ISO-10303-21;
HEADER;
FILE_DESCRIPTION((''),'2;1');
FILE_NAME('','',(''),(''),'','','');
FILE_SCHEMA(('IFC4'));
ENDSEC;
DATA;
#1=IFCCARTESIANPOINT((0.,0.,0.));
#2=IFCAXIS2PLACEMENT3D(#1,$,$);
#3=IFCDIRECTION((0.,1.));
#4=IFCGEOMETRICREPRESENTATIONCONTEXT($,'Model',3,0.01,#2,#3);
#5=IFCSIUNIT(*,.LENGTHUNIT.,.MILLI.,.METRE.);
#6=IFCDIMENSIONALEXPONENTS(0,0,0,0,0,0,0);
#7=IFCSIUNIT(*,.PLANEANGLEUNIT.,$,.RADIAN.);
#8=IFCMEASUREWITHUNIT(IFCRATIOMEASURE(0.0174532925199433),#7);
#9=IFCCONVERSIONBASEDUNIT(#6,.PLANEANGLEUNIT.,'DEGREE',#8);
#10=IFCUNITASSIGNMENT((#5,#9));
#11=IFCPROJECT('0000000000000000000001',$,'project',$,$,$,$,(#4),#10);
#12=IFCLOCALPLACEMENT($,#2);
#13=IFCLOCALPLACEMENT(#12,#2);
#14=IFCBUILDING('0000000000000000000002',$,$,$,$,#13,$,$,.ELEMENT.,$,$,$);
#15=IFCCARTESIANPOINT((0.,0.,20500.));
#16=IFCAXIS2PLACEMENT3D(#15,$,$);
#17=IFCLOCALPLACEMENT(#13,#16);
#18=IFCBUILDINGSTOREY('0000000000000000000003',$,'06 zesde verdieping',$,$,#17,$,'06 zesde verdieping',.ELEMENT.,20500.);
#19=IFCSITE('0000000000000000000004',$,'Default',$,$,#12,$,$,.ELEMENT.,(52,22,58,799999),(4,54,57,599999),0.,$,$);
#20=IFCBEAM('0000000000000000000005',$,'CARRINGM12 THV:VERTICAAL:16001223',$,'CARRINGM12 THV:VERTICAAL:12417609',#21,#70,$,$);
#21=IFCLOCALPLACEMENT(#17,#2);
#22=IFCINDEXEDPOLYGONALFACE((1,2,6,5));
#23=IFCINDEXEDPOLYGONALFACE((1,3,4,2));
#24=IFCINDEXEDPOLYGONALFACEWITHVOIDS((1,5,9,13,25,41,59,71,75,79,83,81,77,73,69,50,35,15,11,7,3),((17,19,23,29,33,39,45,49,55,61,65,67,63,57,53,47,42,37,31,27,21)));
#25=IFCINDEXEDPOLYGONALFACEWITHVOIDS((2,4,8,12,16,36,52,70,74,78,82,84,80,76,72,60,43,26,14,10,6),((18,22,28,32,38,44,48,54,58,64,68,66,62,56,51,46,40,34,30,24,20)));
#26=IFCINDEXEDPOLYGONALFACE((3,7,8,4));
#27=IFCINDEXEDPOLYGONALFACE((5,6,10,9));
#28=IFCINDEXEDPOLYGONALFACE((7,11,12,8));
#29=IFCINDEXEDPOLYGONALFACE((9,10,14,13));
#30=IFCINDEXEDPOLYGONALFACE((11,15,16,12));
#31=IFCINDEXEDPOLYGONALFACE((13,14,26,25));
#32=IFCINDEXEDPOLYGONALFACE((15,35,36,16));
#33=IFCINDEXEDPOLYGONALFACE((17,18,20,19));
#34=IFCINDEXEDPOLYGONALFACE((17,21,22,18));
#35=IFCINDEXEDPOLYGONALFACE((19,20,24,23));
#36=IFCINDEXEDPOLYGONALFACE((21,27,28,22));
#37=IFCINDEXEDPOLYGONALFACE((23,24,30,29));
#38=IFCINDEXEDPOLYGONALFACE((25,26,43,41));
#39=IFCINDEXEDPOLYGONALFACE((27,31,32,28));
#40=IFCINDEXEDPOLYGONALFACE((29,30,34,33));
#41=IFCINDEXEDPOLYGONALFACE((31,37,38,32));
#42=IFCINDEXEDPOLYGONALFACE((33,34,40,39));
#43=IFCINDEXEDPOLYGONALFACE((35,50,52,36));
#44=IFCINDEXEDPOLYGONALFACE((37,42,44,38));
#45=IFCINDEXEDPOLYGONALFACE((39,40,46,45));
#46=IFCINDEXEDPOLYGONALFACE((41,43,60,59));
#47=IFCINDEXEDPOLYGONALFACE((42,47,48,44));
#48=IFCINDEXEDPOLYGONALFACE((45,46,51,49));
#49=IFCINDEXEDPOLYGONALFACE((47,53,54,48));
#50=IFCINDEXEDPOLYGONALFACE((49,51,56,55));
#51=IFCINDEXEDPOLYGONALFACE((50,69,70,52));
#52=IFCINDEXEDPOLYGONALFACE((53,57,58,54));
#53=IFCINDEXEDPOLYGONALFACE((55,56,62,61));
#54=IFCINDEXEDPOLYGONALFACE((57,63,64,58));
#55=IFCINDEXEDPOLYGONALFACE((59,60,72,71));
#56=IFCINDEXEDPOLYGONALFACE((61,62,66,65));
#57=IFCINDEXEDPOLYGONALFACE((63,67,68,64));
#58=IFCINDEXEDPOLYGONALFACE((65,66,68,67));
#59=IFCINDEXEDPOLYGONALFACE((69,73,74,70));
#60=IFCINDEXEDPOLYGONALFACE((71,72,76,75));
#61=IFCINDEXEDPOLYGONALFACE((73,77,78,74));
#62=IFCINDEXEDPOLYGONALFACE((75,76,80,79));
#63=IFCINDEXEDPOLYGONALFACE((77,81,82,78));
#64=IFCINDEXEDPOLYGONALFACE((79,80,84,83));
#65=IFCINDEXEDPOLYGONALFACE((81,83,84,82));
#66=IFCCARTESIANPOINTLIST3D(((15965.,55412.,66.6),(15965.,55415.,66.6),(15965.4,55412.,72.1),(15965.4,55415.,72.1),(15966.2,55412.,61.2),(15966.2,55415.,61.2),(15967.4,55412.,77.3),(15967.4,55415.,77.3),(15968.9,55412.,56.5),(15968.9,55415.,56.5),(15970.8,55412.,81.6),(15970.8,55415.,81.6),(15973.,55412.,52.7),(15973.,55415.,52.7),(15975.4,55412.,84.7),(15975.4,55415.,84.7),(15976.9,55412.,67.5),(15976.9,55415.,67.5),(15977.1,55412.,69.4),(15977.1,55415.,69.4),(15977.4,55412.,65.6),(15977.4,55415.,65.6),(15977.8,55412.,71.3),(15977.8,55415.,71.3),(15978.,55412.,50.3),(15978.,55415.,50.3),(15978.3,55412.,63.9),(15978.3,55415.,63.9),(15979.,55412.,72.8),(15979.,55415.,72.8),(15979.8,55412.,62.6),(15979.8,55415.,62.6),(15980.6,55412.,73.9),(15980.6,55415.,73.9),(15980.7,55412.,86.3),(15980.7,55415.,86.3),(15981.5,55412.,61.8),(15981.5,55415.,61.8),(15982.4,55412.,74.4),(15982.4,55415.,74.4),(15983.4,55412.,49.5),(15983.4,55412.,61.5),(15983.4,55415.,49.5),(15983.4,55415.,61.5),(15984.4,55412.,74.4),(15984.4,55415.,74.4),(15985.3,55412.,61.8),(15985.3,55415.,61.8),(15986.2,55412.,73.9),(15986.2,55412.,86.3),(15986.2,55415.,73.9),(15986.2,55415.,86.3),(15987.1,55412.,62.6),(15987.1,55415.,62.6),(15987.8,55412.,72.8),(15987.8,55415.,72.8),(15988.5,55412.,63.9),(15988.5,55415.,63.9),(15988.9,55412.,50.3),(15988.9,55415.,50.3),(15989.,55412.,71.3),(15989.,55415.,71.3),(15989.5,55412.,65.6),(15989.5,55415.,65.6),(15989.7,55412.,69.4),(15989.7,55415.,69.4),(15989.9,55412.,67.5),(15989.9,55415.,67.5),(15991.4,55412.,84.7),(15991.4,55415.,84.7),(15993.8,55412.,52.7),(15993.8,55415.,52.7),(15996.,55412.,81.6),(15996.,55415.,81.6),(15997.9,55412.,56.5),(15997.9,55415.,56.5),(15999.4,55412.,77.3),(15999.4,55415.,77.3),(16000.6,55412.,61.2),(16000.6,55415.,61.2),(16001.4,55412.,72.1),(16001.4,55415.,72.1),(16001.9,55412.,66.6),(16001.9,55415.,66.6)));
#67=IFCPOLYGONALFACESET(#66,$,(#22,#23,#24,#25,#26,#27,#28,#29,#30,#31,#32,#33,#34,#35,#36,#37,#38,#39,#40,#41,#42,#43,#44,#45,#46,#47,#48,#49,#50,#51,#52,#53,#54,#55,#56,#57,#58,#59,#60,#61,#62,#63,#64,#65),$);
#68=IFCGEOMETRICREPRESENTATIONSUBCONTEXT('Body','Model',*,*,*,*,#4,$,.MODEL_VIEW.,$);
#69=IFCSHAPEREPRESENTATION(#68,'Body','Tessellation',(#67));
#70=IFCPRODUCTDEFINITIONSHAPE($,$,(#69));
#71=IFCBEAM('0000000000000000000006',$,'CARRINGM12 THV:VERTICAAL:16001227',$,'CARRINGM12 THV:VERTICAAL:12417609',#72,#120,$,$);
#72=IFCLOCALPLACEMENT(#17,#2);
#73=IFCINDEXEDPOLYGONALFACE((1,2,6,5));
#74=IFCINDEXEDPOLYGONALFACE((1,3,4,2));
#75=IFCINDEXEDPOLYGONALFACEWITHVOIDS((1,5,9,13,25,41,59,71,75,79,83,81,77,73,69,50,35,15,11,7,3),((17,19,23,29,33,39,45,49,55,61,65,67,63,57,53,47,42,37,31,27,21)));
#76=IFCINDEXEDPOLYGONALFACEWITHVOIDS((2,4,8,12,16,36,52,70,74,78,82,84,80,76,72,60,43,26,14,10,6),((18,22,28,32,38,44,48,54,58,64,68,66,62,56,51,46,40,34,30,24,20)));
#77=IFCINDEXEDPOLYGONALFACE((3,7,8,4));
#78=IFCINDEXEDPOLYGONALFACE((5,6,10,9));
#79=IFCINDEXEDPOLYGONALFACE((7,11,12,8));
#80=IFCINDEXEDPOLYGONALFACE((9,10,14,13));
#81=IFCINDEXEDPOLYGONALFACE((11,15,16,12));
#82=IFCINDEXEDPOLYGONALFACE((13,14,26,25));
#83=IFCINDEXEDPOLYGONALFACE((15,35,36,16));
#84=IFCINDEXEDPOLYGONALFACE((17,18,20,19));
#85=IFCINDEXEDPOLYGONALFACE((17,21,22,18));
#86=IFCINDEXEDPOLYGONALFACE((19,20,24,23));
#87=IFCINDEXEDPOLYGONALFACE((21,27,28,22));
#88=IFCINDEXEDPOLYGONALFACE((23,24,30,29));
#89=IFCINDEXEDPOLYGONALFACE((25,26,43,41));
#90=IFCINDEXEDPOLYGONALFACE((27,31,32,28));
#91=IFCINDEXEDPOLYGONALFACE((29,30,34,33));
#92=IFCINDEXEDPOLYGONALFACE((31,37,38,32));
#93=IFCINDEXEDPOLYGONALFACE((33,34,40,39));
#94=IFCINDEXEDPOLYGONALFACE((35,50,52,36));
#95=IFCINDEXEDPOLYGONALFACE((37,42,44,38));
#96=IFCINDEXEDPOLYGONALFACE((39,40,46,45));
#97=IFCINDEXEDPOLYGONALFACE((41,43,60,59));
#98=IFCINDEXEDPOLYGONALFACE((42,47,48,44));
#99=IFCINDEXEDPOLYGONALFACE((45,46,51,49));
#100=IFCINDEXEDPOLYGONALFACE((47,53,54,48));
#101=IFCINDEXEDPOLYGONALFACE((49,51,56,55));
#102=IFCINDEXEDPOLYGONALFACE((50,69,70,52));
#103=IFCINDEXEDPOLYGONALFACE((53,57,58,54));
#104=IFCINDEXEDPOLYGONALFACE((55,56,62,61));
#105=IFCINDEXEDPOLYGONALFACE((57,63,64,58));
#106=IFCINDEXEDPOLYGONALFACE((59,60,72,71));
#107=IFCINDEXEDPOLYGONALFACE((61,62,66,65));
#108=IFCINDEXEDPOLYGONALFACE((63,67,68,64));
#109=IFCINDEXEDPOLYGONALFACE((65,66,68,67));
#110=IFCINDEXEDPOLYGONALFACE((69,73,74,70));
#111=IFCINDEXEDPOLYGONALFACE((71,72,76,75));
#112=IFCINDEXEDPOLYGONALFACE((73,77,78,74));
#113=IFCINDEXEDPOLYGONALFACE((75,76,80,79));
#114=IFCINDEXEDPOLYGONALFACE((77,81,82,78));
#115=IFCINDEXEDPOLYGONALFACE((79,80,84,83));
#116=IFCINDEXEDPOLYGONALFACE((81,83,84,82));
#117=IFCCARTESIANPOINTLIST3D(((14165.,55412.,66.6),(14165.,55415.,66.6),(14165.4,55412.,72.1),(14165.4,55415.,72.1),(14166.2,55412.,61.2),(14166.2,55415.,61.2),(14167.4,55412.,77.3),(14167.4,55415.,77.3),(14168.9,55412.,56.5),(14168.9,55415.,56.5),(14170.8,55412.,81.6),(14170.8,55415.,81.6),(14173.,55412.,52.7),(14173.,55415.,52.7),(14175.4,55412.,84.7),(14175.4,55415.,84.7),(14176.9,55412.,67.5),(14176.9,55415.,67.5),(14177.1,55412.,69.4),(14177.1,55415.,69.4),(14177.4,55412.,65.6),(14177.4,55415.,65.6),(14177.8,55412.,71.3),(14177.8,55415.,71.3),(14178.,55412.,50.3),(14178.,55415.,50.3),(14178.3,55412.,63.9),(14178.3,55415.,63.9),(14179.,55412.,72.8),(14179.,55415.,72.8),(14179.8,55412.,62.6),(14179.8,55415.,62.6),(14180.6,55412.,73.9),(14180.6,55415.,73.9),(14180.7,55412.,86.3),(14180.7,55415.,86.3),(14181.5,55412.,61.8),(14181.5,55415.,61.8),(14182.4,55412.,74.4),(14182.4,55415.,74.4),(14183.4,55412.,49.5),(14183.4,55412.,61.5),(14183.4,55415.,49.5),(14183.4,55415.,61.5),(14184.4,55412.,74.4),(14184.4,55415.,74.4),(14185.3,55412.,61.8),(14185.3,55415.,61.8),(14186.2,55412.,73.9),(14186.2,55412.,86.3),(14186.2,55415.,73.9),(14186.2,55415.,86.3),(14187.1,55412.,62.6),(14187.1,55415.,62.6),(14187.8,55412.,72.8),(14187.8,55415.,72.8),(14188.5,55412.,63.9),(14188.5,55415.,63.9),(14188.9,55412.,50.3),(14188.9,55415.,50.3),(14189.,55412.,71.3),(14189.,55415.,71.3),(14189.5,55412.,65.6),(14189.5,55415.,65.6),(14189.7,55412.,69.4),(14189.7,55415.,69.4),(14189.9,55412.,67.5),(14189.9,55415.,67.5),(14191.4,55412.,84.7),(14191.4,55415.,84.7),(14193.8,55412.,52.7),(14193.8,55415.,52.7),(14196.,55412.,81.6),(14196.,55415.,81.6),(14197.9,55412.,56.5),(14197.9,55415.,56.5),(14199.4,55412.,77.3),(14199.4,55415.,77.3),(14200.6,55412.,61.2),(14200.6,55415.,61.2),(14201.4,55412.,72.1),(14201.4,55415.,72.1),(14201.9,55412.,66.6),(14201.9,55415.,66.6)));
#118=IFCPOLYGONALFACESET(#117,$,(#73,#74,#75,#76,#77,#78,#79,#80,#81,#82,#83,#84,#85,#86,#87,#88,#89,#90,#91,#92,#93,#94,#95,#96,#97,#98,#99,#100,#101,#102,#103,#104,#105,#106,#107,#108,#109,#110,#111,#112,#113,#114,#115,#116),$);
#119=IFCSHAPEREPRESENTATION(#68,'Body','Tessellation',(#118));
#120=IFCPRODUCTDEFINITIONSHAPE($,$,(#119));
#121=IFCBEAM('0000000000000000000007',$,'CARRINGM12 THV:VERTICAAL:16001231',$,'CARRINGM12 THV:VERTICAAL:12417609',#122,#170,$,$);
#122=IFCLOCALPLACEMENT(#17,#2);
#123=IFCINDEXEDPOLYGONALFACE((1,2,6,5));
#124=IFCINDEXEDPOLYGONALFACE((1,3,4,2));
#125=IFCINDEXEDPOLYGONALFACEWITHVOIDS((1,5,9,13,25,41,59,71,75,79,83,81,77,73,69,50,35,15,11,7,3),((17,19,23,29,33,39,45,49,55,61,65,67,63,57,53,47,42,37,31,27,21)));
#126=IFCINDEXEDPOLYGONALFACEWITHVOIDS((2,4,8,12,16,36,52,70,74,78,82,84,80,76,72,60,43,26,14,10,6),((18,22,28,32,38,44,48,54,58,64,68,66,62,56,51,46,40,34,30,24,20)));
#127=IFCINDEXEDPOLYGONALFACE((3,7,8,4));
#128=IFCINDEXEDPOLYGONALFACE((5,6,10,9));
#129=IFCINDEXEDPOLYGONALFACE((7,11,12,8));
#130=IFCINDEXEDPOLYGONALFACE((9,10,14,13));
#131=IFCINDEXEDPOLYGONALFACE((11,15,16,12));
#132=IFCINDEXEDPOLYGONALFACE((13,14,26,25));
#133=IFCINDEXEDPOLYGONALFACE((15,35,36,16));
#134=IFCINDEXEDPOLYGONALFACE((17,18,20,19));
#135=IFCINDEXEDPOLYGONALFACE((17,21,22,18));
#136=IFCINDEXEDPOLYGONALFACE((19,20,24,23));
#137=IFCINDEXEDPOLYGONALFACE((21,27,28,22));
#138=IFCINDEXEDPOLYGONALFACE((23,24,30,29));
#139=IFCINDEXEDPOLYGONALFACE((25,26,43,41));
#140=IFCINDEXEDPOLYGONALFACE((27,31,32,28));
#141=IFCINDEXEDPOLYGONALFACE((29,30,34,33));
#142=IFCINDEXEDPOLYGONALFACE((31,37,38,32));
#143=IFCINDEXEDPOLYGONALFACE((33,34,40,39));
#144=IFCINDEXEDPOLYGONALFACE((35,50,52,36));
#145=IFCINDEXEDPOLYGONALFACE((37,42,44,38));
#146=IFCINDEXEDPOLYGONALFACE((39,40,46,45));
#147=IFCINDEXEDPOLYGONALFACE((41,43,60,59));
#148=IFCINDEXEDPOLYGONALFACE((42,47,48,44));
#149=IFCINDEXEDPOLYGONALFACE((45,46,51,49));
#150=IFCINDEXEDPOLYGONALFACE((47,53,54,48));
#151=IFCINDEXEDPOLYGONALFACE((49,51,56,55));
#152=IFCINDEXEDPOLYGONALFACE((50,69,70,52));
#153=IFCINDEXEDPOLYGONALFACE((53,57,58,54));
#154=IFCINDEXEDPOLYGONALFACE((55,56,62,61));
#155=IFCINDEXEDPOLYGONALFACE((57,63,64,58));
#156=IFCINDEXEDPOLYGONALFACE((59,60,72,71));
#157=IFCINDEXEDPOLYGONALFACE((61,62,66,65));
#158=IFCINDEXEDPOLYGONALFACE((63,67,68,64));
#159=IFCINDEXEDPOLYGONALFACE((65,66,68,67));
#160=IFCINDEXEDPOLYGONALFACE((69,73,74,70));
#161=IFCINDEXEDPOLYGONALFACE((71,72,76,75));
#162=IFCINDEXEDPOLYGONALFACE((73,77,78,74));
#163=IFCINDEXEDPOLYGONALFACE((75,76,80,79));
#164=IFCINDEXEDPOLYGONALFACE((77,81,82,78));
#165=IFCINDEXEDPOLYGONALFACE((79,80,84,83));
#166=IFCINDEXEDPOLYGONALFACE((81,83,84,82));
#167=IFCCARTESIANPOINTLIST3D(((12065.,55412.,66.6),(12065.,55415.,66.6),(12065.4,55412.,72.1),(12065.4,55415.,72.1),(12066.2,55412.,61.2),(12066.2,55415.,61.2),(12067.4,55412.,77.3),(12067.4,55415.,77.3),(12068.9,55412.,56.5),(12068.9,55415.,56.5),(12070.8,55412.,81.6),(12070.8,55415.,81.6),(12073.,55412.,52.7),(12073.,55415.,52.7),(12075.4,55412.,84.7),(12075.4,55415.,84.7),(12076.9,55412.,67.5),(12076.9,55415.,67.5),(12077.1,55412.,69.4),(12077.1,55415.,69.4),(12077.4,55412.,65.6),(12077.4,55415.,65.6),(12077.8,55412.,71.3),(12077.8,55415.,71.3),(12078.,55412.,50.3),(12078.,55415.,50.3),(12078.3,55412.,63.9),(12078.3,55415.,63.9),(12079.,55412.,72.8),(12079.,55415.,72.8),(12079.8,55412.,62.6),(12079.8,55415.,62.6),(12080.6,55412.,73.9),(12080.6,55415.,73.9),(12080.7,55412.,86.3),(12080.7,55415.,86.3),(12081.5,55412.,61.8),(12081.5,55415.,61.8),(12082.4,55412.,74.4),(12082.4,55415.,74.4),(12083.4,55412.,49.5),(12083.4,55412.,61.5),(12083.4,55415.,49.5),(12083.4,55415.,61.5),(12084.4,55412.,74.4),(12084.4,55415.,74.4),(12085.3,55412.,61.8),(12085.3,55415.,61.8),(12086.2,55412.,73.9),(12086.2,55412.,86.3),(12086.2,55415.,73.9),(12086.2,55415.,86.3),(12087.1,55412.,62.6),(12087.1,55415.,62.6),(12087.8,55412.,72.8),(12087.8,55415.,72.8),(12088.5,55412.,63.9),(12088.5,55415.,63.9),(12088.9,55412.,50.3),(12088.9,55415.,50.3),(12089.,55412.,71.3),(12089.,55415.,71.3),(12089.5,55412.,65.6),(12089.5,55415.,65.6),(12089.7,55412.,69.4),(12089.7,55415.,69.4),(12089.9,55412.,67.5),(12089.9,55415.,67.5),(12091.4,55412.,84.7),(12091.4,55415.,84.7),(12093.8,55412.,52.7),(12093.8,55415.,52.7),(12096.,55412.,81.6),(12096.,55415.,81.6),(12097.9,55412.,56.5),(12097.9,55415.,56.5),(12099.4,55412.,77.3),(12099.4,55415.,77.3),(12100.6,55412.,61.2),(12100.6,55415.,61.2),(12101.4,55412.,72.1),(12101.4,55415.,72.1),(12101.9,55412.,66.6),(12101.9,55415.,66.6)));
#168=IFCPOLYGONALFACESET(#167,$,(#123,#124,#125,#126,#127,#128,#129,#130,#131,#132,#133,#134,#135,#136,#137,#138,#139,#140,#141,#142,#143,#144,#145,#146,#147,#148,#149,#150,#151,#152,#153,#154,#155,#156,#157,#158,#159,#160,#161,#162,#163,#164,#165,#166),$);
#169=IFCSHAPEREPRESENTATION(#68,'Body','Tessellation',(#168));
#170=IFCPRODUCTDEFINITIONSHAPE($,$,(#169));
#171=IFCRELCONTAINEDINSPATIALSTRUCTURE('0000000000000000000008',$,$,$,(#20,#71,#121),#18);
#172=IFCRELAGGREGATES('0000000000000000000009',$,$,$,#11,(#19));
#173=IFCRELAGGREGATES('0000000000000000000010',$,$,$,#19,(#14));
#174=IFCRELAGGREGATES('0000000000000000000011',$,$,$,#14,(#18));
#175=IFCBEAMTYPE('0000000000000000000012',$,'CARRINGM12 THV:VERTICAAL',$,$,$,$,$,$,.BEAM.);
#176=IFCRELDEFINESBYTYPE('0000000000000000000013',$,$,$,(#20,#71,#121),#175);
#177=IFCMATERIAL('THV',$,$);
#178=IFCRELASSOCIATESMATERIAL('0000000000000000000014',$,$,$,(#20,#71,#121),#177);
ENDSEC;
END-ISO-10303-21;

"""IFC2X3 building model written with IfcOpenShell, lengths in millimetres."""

from ifc_helpers import new_model, entity, si_unit, converted_unit, direction, frame, origin, origin_2d_with_axis, place, context, subcontext, project, spatial, hollow_circle, extrude, material, type_object, element, save


model = new_model("IFC2X3")

# Units and contexts
model_context = context("Model", 3, precision=0.01, world=origin(), true_north=direction((0.0, 1.0)))
body_context = subcontext(model_context, "Body", "Model", "MODEL_VIEW")
ifc_project = project(units=[si_unit("LENGTHUNIT", "METRE", prefix="MILLI"), converted_unit("PLANEANGLEUNIT", "DEGREE", entity("IfcRatioMeasure", 0.0174532925199433), si_unit("PLANEANGLEUNIT", "RADIAN"), dimensions=[0, 0, 0, 0, 0, 0, 0])], contexts=[model_context])

# Site, building, storey
site_placement = place(None, origin())
site = spatial("IfcSite", under=ifc_project, at=site_placement, Name="Default", CompositionType="ELEMENT", RefLatitude=(52, 22, 58, 799999), RefLongitude=(4, 54, 57, 599999), RefElevation=0.0)
building_placement = place(site_placement, origin())
building = spatial("IfcBuilding", under=site, at=building_placement, CompositionType="ELEMENT")
storey_placement = place(building_placement, frame((0.0, 0.0, 20500.0)))
storey = spatial("IfcBuildingStorey", under=building, at=storey_placement, Name="06 zesde verdieping", LongName="06 zesde verdieping", CompositionType="ELEMENT", Elevation=20500.0)

# Beams
ifc_material_1 = material(Name="THV")
beam_type_1 = type_object("IfcBeamType", Name="CARRINGM12 THV:VERTICAAL", PredefinedType="BEAM")
beam_1_placement = place(storey_placement, origin())
element("IfcBeam", 1, at=beam_1_placement, inside=storey, type_object=beam_type_1, material=ifc_material_1, Name="CARRINGM12 THV:VERTICAAL:16001223", ObjectType="CARRINGM12 THV:VERTICAAL:12417609", context=body_context, shape_type="SweptSolid", body=[
    extrude(hollow_circle(Radius=18.5, WallThickness=12.0, at=origin_2d_with_axis()), frame((15983.4, 55412.0, 68.0), z_axis=(0.0, 1.0, 0.0), x_axis=(0.0, 0.0, -1.0)), (0.0, 0.0, 1.0), 3.0),
])
beam_2_placement = place(storey_placement, origin())
element("IfcBeam", 2, at=beam_2_placement, inside=storey, type_object=beam_type_1, material=ifc_material_1, Name="CARRINGM12 THV:VERTICAAL:16001227", ObjectType="CARRINGM12 THV:VERTICAAL:12417609", context=body_context, shape_type="SweptSolid", body=[
    extrude(hollow_circle(Radius=18.5, WallThickness=12.0, at=origin_2d_with_axis()), frame((14183.4, 55412.0, 68.0), z_axis=(0.0, 1.0, 0.0), x_axis=(0.0, 0.0, -1.0)), (0.0, 0.0, 1.0), 3.0),
])
beam_3_placement = place(storey_placement, origin())
element("IfcBeam", 3, at=beam_3_placement, inside=storey, type_object=beam_type_1, material=ifc_material_1, Name="CARRINGM12 THV:VERTICAAL:16001231", ObjectType="CARRINGM12 THV:VERTICAAL:12417609", context=body_context, shape_type="SweptSolid", body=[
    extrude(hollow_circle(Radius=18.5, WallThickness=12.0, at=origin_2d_with_axis()), frame((12083.4, 55412.0, 68.0), z_axis=(0.0, 1.0, 0.0), x_axis=(0.0, 0.0, -1.0)), (0.0, 0.0, 1.0), 3.0),
])

save(model, "model.ifc")
